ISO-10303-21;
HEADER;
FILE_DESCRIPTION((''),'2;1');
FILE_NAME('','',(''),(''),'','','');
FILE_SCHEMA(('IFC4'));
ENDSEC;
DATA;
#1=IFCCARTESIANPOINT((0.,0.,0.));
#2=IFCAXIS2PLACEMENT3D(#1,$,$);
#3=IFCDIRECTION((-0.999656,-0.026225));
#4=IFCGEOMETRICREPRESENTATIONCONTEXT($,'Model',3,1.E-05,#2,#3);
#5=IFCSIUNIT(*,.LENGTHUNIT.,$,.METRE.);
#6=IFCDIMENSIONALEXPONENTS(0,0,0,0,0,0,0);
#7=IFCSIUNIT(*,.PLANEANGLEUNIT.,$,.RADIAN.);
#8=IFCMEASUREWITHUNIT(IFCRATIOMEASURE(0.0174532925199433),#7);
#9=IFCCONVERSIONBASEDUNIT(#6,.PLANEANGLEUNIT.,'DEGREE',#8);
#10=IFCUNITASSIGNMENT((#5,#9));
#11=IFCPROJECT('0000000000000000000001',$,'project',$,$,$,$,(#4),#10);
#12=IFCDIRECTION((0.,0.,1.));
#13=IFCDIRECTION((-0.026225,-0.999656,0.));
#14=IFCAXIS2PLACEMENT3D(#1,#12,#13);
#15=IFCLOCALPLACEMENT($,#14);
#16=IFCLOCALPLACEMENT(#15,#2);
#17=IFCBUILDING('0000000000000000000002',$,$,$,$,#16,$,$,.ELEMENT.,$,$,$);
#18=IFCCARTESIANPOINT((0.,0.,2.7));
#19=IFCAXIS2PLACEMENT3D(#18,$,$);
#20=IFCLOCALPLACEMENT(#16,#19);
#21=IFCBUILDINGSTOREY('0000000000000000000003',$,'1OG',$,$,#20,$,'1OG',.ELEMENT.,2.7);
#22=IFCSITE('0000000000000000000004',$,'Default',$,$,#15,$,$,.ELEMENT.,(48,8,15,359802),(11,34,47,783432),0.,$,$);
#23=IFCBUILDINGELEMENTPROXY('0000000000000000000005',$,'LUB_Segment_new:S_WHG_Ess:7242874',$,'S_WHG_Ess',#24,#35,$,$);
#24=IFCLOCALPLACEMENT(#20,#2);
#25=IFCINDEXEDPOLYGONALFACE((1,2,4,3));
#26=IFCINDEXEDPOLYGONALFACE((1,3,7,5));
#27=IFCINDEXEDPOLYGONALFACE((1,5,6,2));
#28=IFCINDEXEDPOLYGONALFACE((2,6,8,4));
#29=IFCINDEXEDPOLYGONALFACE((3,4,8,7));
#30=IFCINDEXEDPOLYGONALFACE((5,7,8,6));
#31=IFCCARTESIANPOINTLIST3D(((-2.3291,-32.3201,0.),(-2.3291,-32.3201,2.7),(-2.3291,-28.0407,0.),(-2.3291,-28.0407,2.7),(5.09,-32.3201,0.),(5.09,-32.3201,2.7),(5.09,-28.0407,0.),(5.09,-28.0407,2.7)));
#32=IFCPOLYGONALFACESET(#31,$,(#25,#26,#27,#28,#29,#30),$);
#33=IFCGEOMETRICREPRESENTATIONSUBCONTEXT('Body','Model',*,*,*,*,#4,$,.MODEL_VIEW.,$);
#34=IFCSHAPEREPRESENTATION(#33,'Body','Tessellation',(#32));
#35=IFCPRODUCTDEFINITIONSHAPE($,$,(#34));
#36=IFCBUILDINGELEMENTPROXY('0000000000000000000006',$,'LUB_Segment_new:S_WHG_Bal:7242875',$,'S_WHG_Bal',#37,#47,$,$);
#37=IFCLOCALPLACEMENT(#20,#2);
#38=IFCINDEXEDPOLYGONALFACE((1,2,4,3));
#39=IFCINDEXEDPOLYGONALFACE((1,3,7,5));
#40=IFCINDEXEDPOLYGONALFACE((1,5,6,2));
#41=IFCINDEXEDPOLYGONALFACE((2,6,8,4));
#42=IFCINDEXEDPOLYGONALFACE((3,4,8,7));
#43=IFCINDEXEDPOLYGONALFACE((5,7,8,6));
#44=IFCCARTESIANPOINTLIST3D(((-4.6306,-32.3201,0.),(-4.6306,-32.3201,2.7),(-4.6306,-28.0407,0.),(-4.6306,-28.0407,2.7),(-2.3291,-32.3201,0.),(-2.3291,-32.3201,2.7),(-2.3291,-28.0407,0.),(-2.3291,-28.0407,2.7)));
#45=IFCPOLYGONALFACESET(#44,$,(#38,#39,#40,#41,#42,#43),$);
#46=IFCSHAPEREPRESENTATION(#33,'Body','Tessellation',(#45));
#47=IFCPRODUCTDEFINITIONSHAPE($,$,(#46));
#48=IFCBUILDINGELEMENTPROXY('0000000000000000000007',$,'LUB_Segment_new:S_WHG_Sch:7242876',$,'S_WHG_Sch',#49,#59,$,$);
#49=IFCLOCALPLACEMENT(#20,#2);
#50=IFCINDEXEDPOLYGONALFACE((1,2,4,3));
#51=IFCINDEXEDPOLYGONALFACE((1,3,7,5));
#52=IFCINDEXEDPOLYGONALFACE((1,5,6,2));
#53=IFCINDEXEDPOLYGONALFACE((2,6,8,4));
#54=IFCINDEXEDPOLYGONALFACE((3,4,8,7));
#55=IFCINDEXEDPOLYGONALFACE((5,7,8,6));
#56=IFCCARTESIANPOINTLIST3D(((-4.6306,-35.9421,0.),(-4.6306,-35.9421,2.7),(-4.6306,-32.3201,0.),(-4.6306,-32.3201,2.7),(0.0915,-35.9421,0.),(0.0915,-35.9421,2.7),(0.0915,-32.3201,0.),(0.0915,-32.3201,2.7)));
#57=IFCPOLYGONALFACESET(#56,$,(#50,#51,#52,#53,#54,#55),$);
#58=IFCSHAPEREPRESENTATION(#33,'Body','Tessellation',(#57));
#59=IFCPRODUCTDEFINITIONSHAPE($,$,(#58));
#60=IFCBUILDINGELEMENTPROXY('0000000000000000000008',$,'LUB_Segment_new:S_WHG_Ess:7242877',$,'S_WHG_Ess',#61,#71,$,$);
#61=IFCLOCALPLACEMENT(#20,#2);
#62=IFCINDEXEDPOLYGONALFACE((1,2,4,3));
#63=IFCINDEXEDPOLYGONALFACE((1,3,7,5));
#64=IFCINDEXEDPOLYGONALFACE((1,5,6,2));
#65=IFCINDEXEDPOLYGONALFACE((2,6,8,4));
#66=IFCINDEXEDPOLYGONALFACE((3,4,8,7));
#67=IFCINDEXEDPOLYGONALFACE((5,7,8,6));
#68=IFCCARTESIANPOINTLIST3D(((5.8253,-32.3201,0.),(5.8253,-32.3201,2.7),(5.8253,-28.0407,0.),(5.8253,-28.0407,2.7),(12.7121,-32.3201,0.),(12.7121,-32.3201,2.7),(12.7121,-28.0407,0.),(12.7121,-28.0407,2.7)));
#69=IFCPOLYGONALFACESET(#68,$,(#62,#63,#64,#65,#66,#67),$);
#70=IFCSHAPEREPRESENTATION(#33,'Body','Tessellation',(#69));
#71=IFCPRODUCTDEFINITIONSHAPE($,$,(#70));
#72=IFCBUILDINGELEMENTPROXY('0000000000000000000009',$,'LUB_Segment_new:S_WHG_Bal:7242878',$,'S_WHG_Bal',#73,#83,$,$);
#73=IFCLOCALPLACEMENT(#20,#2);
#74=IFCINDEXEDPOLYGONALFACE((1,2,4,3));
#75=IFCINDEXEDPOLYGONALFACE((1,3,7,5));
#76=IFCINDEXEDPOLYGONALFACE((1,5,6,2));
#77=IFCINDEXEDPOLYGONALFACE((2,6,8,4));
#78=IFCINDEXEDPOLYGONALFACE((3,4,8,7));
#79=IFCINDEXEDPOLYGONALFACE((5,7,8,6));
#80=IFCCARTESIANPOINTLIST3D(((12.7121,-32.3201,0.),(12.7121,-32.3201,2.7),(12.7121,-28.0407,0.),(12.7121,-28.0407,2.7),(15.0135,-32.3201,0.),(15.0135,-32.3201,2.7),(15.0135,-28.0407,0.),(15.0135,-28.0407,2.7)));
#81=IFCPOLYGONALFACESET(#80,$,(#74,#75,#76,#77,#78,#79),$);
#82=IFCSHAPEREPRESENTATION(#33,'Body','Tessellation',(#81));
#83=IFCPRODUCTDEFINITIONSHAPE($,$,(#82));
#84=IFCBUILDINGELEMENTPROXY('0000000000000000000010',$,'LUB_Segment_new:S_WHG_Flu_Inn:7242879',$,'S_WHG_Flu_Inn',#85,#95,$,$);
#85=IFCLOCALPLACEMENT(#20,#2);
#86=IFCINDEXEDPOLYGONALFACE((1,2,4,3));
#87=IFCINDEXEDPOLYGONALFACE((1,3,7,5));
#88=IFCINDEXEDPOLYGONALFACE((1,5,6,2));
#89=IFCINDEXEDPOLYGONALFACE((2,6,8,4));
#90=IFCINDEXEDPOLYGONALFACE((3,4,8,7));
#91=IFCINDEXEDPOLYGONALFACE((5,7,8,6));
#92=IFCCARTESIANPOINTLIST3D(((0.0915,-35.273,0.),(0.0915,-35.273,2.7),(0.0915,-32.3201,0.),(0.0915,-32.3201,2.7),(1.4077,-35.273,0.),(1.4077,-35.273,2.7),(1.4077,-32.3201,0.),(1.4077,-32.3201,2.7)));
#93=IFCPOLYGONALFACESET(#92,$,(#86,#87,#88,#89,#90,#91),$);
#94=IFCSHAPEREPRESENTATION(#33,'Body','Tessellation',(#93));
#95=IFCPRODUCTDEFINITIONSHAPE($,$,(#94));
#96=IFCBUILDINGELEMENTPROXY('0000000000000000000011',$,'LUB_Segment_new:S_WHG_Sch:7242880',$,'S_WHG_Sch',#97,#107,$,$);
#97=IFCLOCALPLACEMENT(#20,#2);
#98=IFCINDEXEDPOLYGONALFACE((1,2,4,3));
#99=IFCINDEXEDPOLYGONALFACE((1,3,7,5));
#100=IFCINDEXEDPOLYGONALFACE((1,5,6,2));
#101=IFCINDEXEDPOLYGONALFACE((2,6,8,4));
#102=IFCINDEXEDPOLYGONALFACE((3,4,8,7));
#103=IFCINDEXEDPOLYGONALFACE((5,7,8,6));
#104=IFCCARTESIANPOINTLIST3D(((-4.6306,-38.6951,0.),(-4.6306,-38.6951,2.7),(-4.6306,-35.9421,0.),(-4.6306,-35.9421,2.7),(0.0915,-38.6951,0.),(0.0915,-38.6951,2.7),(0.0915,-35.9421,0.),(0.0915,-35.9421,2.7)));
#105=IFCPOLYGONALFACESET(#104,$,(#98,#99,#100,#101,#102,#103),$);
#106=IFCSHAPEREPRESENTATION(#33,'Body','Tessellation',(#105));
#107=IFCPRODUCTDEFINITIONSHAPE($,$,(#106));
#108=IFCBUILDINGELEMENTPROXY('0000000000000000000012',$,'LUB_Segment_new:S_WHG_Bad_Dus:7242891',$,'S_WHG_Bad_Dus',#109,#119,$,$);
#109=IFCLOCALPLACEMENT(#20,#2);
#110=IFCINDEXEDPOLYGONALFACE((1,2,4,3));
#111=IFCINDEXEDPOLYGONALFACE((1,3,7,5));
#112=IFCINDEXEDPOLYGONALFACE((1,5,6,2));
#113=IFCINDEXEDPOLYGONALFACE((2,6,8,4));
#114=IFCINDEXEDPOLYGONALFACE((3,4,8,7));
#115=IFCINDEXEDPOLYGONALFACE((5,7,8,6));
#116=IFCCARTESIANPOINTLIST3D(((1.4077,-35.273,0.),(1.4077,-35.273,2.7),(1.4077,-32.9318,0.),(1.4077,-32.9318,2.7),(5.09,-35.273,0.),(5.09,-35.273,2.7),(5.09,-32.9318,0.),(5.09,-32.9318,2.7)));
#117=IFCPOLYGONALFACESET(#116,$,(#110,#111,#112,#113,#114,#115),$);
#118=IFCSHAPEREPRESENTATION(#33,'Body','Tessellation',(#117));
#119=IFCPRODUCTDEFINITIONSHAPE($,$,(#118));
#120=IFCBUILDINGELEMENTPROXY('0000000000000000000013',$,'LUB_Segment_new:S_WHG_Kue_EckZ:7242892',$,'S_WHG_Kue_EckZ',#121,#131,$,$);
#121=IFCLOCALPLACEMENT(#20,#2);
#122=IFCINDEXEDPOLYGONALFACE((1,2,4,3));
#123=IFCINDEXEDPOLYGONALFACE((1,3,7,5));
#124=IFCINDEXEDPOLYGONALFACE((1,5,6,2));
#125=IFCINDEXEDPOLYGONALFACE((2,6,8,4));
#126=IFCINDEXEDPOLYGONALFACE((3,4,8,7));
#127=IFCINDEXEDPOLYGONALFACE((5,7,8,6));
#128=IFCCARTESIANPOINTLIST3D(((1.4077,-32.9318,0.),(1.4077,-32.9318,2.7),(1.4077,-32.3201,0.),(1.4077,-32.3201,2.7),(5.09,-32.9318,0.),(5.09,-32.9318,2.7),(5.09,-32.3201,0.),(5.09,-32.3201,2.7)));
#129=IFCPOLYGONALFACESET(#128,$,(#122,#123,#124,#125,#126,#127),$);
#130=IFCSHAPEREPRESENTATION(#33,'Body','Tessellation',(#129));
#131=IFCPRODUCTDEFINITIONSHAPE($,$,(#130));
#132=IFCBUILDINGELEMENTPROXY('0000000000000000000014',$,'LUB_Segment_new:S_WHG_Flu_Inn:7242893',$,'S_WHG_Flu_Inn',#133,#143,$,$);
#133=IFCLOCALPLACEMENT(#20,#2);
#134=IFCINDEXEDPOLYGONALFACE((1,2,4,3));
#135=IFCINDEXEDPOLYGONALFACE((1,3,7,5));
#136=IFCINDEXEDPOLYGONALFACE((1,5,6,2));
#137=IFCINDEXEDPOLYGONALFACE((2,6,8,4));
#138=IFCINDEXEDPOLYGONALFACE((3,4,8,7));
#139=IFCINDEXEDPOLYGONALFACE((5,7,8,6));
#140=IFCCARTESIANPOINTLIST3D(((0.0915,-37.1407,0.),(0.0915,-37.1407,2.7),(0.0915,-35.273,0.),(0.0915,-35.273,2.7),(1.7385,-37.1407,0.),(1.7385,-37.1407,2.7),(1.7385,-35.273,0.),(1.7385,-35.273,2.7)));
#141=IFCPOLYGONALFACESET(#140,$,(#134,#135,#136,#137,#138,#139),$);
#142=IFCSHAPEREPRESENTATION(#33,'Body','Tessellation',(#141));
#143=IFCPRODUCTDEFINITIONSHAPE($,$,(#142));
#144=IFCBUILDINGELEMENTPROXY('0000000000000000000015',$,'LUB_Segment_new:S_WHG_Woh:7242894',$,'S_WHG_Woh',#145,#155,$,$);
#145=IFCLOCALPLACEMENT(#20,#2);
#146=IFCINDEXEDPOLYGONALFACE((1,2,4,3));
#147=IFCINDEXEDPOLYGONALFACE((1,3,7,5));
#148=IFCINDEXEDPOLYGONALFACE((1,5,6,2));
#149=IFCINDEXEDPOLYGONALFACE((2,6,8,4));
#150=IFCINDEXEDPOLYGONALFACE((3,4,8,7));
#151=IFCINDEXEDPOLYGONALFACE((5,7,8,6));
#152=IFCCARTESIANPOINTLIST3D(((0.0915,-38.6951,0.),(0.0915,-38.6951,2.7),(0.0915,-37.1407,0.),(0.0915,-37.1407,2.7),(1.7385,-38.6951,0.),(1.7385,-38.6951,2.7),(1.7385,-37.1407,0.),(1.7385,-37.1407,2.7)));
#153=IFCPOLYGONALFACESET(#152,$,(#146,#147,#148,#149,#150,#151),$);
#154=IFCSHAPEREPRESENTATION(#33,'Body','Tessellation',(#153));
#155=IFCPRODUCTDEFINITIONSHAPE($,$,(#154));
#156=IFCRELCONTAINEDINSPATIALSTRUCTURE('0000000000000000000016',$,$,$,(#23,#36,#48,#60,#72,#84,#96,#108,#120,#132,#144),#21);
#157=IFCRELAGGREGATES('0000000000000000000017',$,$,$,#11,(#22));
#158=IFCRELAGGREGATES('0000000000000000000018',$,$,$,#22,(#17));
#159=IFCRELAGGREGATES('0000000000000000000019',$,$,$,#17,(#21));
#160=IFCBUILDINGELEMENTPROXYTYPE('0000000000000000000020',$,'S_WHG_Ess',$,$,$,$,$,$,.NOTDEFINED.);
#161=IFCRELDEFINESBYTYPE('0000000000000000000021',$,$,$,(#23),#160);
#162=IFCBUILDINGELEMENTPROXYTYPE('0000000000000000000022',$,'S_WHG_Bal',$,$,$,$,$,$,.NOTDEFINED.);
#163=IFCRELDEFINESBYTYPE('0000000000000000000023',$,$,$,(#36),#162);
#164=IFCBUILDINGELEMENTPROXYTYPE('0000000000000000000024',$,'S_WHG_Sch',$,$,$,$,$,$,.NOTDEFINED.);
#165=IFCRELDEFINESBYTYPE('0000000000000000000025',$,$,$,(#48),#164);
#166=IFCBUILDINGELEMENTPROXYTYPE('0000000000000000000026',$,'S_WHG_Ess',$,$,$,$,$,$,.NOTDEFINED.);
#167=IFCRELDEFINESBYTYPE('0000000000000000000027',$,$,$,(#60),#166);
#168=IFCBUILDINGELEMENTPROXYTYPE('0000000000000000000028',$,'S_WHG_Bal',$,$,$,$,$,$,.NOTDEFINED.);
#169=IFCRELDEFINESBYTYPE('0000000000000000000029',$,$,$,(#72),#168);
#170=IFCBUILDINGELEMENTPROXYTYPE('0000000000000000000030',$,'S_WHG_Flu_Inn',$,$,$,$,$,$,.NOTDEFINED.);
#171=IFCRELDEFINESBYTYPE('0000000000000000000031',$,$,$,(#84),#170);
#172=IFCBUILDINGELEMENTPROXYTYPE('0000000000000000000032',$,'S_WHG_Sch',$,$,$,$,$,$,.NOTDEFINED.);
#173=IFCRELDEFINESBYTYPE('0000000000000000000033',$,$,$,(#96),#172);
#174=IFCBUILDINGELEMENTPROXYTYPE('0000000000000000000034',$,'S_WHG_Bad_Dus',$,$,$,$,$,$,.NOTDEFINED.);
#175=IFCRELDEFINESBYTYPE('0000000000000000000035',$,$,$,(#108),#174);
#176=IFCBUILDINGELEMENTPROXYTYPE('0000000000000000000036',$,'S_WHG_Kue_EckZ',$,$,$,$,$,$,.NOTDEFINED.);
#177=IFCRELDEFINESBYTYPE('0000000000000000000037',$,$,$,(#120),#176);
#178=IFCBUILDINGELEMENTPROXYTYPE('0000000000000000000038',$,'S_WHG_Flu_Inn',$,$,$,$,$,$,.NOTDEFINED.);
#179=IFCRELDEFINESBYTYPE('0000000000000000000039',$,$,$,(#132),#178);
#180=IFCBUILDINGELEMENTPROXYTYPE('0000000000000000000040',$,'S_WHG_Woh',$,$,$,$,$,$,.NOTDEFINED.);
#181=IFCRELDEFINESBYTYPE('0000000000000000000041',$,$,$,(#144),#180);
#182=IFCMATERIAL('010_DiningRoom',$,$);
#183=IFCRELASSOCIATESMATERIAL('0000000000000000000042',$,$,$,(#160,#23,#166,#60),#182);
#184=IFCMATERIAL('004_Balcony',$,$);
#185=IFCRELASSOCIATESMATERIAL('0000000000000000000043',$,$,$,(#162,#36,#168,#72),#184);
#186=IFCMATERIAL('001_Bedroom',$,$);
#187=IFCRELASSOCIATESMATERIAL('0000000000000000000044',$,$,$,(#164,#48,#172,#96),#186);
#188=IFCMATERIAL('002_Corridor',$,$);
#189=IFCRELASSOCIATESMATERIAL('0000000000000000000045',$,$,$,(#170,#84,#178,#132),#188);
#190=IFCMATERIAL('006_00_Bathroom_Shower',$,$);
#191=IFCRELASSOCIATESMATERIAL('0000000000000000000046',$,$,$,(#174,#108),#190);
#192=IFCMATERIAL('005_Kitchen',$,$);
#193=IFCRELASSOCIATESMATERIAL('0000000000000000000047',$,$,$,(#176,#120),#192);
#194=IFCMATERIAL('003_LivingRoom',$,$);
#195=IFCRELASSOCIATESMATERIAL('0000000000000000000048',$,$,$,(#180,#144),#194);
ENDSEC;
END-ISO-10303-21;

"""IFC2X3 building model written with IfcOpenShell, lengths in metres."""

from ifc_helpers import new_model, entity, si_unit, converted_unit, direction, frame, origin, origin_2d_with_axis, place, context, subcontext, project, spatial, rectangle, extrude, source, transform, mapped, material, type_object, type_shapes, element, save


model = new_model("IFC2X3")

# Units and contexts
model_context = context("Model", 3, precision=1e-05, world=origin(), true_north=direction((-0.999656, -0.026225)))
body_context = subcontext(model_context, "Body", "Model", "MODEL_VIEW")
ifc_project = project(units=[si_unit("LENGTHUNIT", "METRE"), converted_unit("PLANEANGLEUNIT", "DEGREE", entity("IfcRatioMeasure", 0.0174532925199433), si_unit("PLANEANGLEUNIT", "RADIAN"), dimensions=[0, 0, 0, 0, 0, 0, 0])], contexts=[model_context])

# Site, building, storey
site_placement = place(None, frame((0.0, 0.0, 0.0), z_axis=(0.0, 0.0, 1.0), x_axis=(-0.026225, -0.999656, 0.0)))
site = spatial("IfcSite", under=ifc_project, at=site_placement, Name="Default", CompositionType="ELEMENT", RefLatitude=(48, 8, 15, 359802), RefLongitude=(11, 34, 47, 783432), RefElevation=0.0)
building_placement = place(site_placement, origin())
building = spatial("IfcBuilding", under=site, at=building_placement, CompositionType="ELEMENT")
storey_placement = place(building_placement, frame((0.0, 0.0, 2.7)))
storey = spatial("IfcBuildingStorey", under=building, at=storey_placement, Name="1OG", LongName="1OG", CompositionType="ELEMENT", Elevation=2.7)

# Building element proxies
ifc_material_1 = material(Name="010_DiningRoom")
building_element_proxy_type_1 = type_object("IfcBuildingElementProxyType", Name="S_WHG_Ess", PredefinedType="NOTDEFINED", material=ifc_material_1)
shared_shape_1 = source(origin(), body_context, "Body", "SweptSolid", [
    extrude(rectangle(XDim=7.4191, YDim=4.2794, at=origin_2d_with_axis()), frame((0.0, 0.0, 0.0), z_axis=(0.0, 0.0, 1.0), x_axis=(-1.0, 0.0, 0.0)), (0.0, 0.0, 1.0), 2.7),
])
type_shapes(building_element_proxy_type_1, [shared_shape_1])
proxy_1_placement = place(storey_placement, frame((1.3805, -30.1804, 0.0)))
element("IfcBuildingElementProxy", 1, at=proxy_1_placement, inside=storey, type_object=building_element_proxy_type_1, material=ifc_material_1, Name="LUB_Segment_new:S_WHG_Ess:7242874", ObjectType="S_WHG_Ess", context=body_context, shape_type="MappedRepresentation", body=[
    mapped(shared_shape_1, transform((0.0, 0.0, 0.0), scale=1.0)),
])
ifc_material_2 = material(Name="004_Balcony")
building_element_proxy_type_2 = type_object("IfcBuildingElementProxyType", Name="S_WHG_Bal", PredefinedType="NOTDEFINED", material=ifc_material_2)
shared_shape_2 = source(origin(), body_context, "Body", "SweptSolid", [
    extrude(rectangle(XDim=2.3015, YDim=4.2794, at=origin_2d_with_axis()), frame((0.0, 0.0, 0.0), z_axis=(0.0, 0.0, 1.0), x_axis=(-1.0, 0.0, 0.0)), (0.0, 0.0, 1.0), 2.7),
])
type_shapes(building_element_proxy_type_2, [shared_shape_2])
proxy_2_placement = place(storey_placement, frame((-3.4798, -30.1804, 0.0)))
element("IfcBuildingElementProxy", 2, at=proxy_2_placement, inside=storey, type_object=building_element_proxy_type_2, material=ifc_material_2, Name="LUB_Segment_new:S_WHG_Bal:7242875", ObjectType="S_WHG_Bal", context=body_context, shape_type="MappedRepresentation", body=[
    mapped(shared_shape_2, transform((0.0, 0.0, 0.0), scale=1.0)),
])
ifc_material_3 = material(Name="001_Bedroom")
building_element_proxy_type_3 = type_object("IfcBuildingElementProxyType", Name="S_WHG_Sch", PredefinedType="NOTDEFINED", material=ifc_material_3)
shared_shape_3 = source(origin(), body_context, "Body", "SweptSolid", [
    extrude(rectangle(XDim=4.7221, YDim=3.6221, at=origin_2d_with_axis()), frame((0.0, 0.0, 0.0), z_axis=(0.0, 0.0, 1.0), x_axis=(-1.0, 0.0, 0.0)), (0.0, 0.0, 1.0), 2.7),
])
type_shapes(building_element_proxy_type_3, [shared_shape_3])
proxy_3_placement = place(storey_placement, frame((-2.2695, -34.1311, 0.0)))
element("IfcBuildingElementProxy", 3, at=proxy_3_placement, inside=storey, type_object=building_element_proxy_type_3, material=ifc_material_3, Name="LUB_Segment_new:S_WHG_Sch:7242876", ObjectType="S_WHG_Sch", context=body_context, shape_type="MappedRepresentation", body=[
    mapped(shared_shape_3, transform((0.0, 0.0, 0.0), scale=1.0)),
])
building_element_proxy_type_4 = type_object("IfcBuildingElementProxyType", Name="S_WHG_Ess", PredefinedType="NOTDEFINED", material=ifc_material_1)
shared_shape_4 = source(origin(), body_context, "Body", "SweptSolid", [
    extrude(rectangle(XDim=6.8868, YDim=4.2794, at=origin_2d_with_axis()), frame((0.0, 0.0, 0.0), z_axis=(0.0, 0.0, 1.0), x_axis=(-1.0, 0.0, 0.0)), (0.0, 0.0, 1.0), 2.7),
])
type_shapes(building_element_proxy_type_4, [shared_shape_4])
proxy_4_placement = place(storey_placement, frame((9.2687, -30.1804, 0.0)))
element("IfcBuildingElementProxy", 4, at=proxy_4_placement, inside=storey, type_object=building_element_proxy_type_4, material=ifc_material_1, Name="LUB_Segment_new:S_WHG_Ess:7242877", ObjectType="S_WHG_Ess", context=body_context, shape_type="MappedRepresentation", body=[
    mapped(shared_shape_4, transform((0.0, 0.0, 0.0), scale=1.0)),
])
building_element_proxy_type_5 = type_object("IfcBuildingElementProxyType", Name="S_WHG_Bal", PredefinedType="NOTDEFINED", material=ifc_material_2)
shared_shape_5 = source(origin(), body_context, "Body", "SweptSolid", [
    extrude(rectangle(XDim=4.2794, YDim=2.3015, at=origin_2d_with_axis()), frame((0.0, 0.0, 0.0), z_axis=(0.0, 0.0, 1.0), x_axis=(0.0, 1.0, 0.0)), (0.0, 0.0, 1.0), 2.7),
])
type_shapes(building_element_proxy_type_5, [shared_shape_5])
proxy_5_placement = place(storey_placement, frame((13.8628, -30.1804, 0.0), z_axis=(0.0, 0.0, 1.0), x_axis=(-1.0, 0.0, 0.0)))
element("IfcBuildingElementProxy", 5, at=proxy_5_placement, inside=storey, type_object=building_element_proxy_type_5, material=ifc_material_2, Name="LUB_Segment_new:S_WHG_Bal:7242878", ObjectType="S_WHG_Bal", context=body_context, shape_type="MappedRepresentation", body=[
    mapped(shared_shape_5, transform((0.0, 0.0, 0.0), scale=1.0)),
])
ifc_material_4 = material(Name="002_Corridor")
building_element_proxy_type_6 = type_object("IfcBuildingElementProxyType", Name="S_WHG_Flu_Inn", PredefinedType="NOTDEFINED", material=ifc_material_4)
shared_shape_6 = source(origin(), body_context, "Body", "SweptSolid", [
    extrude(rectangle(XDim=1.3162, YDim=2.9529, at=origin_2d_with_axis()), frame((0.0, 0.0, 0.0), z_axis=(0.0, 0.0, 1.0), x_axis=(-1.0, 0.0, 0.0)), (0.0, 0.0, 1.0), 2.7),
])
type_shapes(building_element_proxy_type_6, [shared_shape_6])
proxy_6_placement = place(storey_placement, frame((0.7496, -33.7966, 0.0)))
element("IfcBuildingElementProxy", 6, at=proxy_6_placement, inside=storey, type_object=building_element_proxy_type_6, material=ifc_material_4, Name="LUB_Segment_new:S_WHG_Flu_Inn:7242879", ObjectType="S_WHG_Flu_Inn", context=body_context, shape_type="MappedRepresentation", body=[
    mapped(shared_shape_6, transform((0.0, 0.0, 0.0), scale=1.0)),
])
building_element_proxy_type_7 = type_object("IfcBuildingElementProxyType", Name="S_WHG_Sch", PredefinedType="NOTDEFINED", material=ifc_material_3)
shared_shape_7 = source(origin(), body_context, "Body", "SweptSolid", [
    extrude(rectangle(XDim=4.7221, YDim=2.7529, at=origin_2d_with_axis()), frame((0.0, 0.0, 0.0), z_axis=(0.0, 0.0, 1.0), x_axis=(-1.0, 0.0, 0.0)), (0.0, 0.0, 1.0), 2.7),
])
type_shapes(building_element_proxy_type_7, [shared_shape_7])
proxy_7_placement = place(storey_placement, frame((-2.2695, -37.3186, 0.0)))
element("IfcBuildingElementProxy", 7, at=proxy_7_placement, inside=storey, type_object=building_element_proxy_type_7, material=ifc_material_3, Name="LUB_Segment_new:S_WHG_Sch:7242880", ObjectType="S_WHG_Sch", context=body_context, shape_type="MappedRepresentation", body=[
    mapped(shared_shape_7, transform((0.0, 0.0, 0.0), scale=1.0)),
])
ifc_material_5 = material(Name="006_00_Bathroom_Shower")
building_element_proxy_type_8 = type_object("IfcBuildingElementProxyType", Name="S_WHG_Bad_Dus", PredefinedType="NOTDEFINED", material=ifc_material_5)
shared_shape_8 = source(origin(), body_context, "Body", "SweptSolid", [
    extrude(rectangle(XDim=2.3412, YDim=3.6824, at=origin_2d_with_axis()), frame((0.0, 0.0, 0.0), z_axis=(0.0, 0.0, 1.0), x_axis=(0.0, 1.0, 0.0)), (0.0, 0.0, 1.0), 2.7),
])
type_shapes(building_element_proxy_type_8, [shared_shape_8])
proxy_8_placement = place(storey_placement, frame((3.2488, -34.1024, 0.0)))
element("IfcBuildingElementProxy", 8, at=proxy_8_placement, inside=storey, type_object=building_element_proxy_type_8, material=ifc_material_5, Name="LUB_Segment_new:S_WHG_Bad_Dus:7242891", ObjectType="S_WHG_Bad_Dus", context=body_context, shape_type="MappedRepresentation", body=[
    mapped(shared_shape_8, transform((0.0, 0.0, 0.0), scale=1.0)),
])
ifc_material_6 = material(Name="005_Kitchen")
building_element_proxy_type_9 = type_object("IfcBuildingElementProxyType", Name="S_WHG_Kue_EckZ", PredefinedType="NOTDEFINED", material=ifc_material_6)
shared_shape_9 = source(origin(), body_context, "Body", "SweptSolid", [
    extrude(rectangle(XDim=0.6118, YDim=3.6824, at=origin_2d_with_axis()), frame((0.0, 0.0, 0.0), z_axis=(0.0, 0.0, 1.0), x_axis=(0.0, 1.0, 0.0)), (0.0, 0.0, 1.0), 2.7),
])
type_shapes(building_element_proxy_type_9, [shared_shape_9])
proxy_9_placement = place(storey_placement, frame((3.2488, -32.626, 0.0)))
element("IfcBuildingElementProxy", 9, at=proxy_9_placement, inside=storey, type_object=building_element_proxy_type_9, material=ifc_material_6, Name="LUB_Segment_new:S_WHG_Kue_EckZ:7242892", ObjectType="S_WHG_Kue_EckZ", context=body_context, shape_type="MappedRepresentation", body=[
    mapped(shared_shape_9, transform((0.0, 0.0, 0.0), scale=1.0)),
])
building_element_proxy_type_10 = type_object("IfcBuildingElementProxyType", Name="S_WHG_Flu_Inn", PredefinedType="NOTDEFINED", material=ifc_material_4)
shared_shape_10 = source(origin(), body_context, "Body", "SweptSolid", [
    extrude(rectangle(XDim=1.6471, YDim=1.8676, at=origin_2d_with_axis()), frame((0.0, 0.0, 0.0), z_axis=(0.0, 0.0, 1.0), x_axis=(-1.0, 0.0, 0.0)), (0.0, 0.0, 1.0), 2.7),
])
type_shapes(building_element_proxy_type_10, [shared_shape_10])
proxy_10_placement = place(storey_placement, frame((0.915, -36.2068, 0.0)))
element("IfcBuildingElementProxy", 10, at=proxy_10_placement, inside=storey, type_object=building_element_proxy_type_10, material=ifc_material_4, Name="LUB_Segment_new:S_WHG_Flu_Inn:7242893", ObjectType="S_WHG_Flu_Inn", context=body_context, shape_type="MappedRepresentation", body=[
    mapped(shared_shape_10, transform((0.0, 0.0, 0.0), scale=1.0)),
])
ifc_material_7 = material(Name="003_LivingRoom")
building_element_proxy_type_11 = type_object("IfcBuildingElementProxyType", Name="S_WHG_Woh", PredefinedType="NOTDEFINED", material=ifc_material_7)
shared_shape_11 = source(origin(), body_context, "Body", "SweptSolid", [
    extrude(rectangle(XDim=1.6471, YDim=1.5544, at=origin_2d_with_axis()), frame((0.0, 0.0, 0.0), z_axis=(0.0, 0.0, 1.0), x_axis=(-1.0, 0.0, 0.0)), (0.0, 0.0, 1.0), 2.7),
])
type_shapes(building_element_proxy_type_11, [shared_shape_11])
proxy_11_placement = place(storey_placement, frame((0.915, -37.9179, 0.0)))
element("IfcBuildingElementProxy", 11, at=proxy_11_placement, inside=storey, type_object=building_element_proxy_type_11, material=ifc_material_7, Name="LUB_Segment_new:S_WHG_Woh:7242894", ObjectType="S_WHG_Woh", context=body_context, shape_type="MappedRepresentation", body=[
    mapped(shared_shape_11, transform((0.0, 0.0, 0.0), scale=1.0)),
])

save(model, "model.ifc")
